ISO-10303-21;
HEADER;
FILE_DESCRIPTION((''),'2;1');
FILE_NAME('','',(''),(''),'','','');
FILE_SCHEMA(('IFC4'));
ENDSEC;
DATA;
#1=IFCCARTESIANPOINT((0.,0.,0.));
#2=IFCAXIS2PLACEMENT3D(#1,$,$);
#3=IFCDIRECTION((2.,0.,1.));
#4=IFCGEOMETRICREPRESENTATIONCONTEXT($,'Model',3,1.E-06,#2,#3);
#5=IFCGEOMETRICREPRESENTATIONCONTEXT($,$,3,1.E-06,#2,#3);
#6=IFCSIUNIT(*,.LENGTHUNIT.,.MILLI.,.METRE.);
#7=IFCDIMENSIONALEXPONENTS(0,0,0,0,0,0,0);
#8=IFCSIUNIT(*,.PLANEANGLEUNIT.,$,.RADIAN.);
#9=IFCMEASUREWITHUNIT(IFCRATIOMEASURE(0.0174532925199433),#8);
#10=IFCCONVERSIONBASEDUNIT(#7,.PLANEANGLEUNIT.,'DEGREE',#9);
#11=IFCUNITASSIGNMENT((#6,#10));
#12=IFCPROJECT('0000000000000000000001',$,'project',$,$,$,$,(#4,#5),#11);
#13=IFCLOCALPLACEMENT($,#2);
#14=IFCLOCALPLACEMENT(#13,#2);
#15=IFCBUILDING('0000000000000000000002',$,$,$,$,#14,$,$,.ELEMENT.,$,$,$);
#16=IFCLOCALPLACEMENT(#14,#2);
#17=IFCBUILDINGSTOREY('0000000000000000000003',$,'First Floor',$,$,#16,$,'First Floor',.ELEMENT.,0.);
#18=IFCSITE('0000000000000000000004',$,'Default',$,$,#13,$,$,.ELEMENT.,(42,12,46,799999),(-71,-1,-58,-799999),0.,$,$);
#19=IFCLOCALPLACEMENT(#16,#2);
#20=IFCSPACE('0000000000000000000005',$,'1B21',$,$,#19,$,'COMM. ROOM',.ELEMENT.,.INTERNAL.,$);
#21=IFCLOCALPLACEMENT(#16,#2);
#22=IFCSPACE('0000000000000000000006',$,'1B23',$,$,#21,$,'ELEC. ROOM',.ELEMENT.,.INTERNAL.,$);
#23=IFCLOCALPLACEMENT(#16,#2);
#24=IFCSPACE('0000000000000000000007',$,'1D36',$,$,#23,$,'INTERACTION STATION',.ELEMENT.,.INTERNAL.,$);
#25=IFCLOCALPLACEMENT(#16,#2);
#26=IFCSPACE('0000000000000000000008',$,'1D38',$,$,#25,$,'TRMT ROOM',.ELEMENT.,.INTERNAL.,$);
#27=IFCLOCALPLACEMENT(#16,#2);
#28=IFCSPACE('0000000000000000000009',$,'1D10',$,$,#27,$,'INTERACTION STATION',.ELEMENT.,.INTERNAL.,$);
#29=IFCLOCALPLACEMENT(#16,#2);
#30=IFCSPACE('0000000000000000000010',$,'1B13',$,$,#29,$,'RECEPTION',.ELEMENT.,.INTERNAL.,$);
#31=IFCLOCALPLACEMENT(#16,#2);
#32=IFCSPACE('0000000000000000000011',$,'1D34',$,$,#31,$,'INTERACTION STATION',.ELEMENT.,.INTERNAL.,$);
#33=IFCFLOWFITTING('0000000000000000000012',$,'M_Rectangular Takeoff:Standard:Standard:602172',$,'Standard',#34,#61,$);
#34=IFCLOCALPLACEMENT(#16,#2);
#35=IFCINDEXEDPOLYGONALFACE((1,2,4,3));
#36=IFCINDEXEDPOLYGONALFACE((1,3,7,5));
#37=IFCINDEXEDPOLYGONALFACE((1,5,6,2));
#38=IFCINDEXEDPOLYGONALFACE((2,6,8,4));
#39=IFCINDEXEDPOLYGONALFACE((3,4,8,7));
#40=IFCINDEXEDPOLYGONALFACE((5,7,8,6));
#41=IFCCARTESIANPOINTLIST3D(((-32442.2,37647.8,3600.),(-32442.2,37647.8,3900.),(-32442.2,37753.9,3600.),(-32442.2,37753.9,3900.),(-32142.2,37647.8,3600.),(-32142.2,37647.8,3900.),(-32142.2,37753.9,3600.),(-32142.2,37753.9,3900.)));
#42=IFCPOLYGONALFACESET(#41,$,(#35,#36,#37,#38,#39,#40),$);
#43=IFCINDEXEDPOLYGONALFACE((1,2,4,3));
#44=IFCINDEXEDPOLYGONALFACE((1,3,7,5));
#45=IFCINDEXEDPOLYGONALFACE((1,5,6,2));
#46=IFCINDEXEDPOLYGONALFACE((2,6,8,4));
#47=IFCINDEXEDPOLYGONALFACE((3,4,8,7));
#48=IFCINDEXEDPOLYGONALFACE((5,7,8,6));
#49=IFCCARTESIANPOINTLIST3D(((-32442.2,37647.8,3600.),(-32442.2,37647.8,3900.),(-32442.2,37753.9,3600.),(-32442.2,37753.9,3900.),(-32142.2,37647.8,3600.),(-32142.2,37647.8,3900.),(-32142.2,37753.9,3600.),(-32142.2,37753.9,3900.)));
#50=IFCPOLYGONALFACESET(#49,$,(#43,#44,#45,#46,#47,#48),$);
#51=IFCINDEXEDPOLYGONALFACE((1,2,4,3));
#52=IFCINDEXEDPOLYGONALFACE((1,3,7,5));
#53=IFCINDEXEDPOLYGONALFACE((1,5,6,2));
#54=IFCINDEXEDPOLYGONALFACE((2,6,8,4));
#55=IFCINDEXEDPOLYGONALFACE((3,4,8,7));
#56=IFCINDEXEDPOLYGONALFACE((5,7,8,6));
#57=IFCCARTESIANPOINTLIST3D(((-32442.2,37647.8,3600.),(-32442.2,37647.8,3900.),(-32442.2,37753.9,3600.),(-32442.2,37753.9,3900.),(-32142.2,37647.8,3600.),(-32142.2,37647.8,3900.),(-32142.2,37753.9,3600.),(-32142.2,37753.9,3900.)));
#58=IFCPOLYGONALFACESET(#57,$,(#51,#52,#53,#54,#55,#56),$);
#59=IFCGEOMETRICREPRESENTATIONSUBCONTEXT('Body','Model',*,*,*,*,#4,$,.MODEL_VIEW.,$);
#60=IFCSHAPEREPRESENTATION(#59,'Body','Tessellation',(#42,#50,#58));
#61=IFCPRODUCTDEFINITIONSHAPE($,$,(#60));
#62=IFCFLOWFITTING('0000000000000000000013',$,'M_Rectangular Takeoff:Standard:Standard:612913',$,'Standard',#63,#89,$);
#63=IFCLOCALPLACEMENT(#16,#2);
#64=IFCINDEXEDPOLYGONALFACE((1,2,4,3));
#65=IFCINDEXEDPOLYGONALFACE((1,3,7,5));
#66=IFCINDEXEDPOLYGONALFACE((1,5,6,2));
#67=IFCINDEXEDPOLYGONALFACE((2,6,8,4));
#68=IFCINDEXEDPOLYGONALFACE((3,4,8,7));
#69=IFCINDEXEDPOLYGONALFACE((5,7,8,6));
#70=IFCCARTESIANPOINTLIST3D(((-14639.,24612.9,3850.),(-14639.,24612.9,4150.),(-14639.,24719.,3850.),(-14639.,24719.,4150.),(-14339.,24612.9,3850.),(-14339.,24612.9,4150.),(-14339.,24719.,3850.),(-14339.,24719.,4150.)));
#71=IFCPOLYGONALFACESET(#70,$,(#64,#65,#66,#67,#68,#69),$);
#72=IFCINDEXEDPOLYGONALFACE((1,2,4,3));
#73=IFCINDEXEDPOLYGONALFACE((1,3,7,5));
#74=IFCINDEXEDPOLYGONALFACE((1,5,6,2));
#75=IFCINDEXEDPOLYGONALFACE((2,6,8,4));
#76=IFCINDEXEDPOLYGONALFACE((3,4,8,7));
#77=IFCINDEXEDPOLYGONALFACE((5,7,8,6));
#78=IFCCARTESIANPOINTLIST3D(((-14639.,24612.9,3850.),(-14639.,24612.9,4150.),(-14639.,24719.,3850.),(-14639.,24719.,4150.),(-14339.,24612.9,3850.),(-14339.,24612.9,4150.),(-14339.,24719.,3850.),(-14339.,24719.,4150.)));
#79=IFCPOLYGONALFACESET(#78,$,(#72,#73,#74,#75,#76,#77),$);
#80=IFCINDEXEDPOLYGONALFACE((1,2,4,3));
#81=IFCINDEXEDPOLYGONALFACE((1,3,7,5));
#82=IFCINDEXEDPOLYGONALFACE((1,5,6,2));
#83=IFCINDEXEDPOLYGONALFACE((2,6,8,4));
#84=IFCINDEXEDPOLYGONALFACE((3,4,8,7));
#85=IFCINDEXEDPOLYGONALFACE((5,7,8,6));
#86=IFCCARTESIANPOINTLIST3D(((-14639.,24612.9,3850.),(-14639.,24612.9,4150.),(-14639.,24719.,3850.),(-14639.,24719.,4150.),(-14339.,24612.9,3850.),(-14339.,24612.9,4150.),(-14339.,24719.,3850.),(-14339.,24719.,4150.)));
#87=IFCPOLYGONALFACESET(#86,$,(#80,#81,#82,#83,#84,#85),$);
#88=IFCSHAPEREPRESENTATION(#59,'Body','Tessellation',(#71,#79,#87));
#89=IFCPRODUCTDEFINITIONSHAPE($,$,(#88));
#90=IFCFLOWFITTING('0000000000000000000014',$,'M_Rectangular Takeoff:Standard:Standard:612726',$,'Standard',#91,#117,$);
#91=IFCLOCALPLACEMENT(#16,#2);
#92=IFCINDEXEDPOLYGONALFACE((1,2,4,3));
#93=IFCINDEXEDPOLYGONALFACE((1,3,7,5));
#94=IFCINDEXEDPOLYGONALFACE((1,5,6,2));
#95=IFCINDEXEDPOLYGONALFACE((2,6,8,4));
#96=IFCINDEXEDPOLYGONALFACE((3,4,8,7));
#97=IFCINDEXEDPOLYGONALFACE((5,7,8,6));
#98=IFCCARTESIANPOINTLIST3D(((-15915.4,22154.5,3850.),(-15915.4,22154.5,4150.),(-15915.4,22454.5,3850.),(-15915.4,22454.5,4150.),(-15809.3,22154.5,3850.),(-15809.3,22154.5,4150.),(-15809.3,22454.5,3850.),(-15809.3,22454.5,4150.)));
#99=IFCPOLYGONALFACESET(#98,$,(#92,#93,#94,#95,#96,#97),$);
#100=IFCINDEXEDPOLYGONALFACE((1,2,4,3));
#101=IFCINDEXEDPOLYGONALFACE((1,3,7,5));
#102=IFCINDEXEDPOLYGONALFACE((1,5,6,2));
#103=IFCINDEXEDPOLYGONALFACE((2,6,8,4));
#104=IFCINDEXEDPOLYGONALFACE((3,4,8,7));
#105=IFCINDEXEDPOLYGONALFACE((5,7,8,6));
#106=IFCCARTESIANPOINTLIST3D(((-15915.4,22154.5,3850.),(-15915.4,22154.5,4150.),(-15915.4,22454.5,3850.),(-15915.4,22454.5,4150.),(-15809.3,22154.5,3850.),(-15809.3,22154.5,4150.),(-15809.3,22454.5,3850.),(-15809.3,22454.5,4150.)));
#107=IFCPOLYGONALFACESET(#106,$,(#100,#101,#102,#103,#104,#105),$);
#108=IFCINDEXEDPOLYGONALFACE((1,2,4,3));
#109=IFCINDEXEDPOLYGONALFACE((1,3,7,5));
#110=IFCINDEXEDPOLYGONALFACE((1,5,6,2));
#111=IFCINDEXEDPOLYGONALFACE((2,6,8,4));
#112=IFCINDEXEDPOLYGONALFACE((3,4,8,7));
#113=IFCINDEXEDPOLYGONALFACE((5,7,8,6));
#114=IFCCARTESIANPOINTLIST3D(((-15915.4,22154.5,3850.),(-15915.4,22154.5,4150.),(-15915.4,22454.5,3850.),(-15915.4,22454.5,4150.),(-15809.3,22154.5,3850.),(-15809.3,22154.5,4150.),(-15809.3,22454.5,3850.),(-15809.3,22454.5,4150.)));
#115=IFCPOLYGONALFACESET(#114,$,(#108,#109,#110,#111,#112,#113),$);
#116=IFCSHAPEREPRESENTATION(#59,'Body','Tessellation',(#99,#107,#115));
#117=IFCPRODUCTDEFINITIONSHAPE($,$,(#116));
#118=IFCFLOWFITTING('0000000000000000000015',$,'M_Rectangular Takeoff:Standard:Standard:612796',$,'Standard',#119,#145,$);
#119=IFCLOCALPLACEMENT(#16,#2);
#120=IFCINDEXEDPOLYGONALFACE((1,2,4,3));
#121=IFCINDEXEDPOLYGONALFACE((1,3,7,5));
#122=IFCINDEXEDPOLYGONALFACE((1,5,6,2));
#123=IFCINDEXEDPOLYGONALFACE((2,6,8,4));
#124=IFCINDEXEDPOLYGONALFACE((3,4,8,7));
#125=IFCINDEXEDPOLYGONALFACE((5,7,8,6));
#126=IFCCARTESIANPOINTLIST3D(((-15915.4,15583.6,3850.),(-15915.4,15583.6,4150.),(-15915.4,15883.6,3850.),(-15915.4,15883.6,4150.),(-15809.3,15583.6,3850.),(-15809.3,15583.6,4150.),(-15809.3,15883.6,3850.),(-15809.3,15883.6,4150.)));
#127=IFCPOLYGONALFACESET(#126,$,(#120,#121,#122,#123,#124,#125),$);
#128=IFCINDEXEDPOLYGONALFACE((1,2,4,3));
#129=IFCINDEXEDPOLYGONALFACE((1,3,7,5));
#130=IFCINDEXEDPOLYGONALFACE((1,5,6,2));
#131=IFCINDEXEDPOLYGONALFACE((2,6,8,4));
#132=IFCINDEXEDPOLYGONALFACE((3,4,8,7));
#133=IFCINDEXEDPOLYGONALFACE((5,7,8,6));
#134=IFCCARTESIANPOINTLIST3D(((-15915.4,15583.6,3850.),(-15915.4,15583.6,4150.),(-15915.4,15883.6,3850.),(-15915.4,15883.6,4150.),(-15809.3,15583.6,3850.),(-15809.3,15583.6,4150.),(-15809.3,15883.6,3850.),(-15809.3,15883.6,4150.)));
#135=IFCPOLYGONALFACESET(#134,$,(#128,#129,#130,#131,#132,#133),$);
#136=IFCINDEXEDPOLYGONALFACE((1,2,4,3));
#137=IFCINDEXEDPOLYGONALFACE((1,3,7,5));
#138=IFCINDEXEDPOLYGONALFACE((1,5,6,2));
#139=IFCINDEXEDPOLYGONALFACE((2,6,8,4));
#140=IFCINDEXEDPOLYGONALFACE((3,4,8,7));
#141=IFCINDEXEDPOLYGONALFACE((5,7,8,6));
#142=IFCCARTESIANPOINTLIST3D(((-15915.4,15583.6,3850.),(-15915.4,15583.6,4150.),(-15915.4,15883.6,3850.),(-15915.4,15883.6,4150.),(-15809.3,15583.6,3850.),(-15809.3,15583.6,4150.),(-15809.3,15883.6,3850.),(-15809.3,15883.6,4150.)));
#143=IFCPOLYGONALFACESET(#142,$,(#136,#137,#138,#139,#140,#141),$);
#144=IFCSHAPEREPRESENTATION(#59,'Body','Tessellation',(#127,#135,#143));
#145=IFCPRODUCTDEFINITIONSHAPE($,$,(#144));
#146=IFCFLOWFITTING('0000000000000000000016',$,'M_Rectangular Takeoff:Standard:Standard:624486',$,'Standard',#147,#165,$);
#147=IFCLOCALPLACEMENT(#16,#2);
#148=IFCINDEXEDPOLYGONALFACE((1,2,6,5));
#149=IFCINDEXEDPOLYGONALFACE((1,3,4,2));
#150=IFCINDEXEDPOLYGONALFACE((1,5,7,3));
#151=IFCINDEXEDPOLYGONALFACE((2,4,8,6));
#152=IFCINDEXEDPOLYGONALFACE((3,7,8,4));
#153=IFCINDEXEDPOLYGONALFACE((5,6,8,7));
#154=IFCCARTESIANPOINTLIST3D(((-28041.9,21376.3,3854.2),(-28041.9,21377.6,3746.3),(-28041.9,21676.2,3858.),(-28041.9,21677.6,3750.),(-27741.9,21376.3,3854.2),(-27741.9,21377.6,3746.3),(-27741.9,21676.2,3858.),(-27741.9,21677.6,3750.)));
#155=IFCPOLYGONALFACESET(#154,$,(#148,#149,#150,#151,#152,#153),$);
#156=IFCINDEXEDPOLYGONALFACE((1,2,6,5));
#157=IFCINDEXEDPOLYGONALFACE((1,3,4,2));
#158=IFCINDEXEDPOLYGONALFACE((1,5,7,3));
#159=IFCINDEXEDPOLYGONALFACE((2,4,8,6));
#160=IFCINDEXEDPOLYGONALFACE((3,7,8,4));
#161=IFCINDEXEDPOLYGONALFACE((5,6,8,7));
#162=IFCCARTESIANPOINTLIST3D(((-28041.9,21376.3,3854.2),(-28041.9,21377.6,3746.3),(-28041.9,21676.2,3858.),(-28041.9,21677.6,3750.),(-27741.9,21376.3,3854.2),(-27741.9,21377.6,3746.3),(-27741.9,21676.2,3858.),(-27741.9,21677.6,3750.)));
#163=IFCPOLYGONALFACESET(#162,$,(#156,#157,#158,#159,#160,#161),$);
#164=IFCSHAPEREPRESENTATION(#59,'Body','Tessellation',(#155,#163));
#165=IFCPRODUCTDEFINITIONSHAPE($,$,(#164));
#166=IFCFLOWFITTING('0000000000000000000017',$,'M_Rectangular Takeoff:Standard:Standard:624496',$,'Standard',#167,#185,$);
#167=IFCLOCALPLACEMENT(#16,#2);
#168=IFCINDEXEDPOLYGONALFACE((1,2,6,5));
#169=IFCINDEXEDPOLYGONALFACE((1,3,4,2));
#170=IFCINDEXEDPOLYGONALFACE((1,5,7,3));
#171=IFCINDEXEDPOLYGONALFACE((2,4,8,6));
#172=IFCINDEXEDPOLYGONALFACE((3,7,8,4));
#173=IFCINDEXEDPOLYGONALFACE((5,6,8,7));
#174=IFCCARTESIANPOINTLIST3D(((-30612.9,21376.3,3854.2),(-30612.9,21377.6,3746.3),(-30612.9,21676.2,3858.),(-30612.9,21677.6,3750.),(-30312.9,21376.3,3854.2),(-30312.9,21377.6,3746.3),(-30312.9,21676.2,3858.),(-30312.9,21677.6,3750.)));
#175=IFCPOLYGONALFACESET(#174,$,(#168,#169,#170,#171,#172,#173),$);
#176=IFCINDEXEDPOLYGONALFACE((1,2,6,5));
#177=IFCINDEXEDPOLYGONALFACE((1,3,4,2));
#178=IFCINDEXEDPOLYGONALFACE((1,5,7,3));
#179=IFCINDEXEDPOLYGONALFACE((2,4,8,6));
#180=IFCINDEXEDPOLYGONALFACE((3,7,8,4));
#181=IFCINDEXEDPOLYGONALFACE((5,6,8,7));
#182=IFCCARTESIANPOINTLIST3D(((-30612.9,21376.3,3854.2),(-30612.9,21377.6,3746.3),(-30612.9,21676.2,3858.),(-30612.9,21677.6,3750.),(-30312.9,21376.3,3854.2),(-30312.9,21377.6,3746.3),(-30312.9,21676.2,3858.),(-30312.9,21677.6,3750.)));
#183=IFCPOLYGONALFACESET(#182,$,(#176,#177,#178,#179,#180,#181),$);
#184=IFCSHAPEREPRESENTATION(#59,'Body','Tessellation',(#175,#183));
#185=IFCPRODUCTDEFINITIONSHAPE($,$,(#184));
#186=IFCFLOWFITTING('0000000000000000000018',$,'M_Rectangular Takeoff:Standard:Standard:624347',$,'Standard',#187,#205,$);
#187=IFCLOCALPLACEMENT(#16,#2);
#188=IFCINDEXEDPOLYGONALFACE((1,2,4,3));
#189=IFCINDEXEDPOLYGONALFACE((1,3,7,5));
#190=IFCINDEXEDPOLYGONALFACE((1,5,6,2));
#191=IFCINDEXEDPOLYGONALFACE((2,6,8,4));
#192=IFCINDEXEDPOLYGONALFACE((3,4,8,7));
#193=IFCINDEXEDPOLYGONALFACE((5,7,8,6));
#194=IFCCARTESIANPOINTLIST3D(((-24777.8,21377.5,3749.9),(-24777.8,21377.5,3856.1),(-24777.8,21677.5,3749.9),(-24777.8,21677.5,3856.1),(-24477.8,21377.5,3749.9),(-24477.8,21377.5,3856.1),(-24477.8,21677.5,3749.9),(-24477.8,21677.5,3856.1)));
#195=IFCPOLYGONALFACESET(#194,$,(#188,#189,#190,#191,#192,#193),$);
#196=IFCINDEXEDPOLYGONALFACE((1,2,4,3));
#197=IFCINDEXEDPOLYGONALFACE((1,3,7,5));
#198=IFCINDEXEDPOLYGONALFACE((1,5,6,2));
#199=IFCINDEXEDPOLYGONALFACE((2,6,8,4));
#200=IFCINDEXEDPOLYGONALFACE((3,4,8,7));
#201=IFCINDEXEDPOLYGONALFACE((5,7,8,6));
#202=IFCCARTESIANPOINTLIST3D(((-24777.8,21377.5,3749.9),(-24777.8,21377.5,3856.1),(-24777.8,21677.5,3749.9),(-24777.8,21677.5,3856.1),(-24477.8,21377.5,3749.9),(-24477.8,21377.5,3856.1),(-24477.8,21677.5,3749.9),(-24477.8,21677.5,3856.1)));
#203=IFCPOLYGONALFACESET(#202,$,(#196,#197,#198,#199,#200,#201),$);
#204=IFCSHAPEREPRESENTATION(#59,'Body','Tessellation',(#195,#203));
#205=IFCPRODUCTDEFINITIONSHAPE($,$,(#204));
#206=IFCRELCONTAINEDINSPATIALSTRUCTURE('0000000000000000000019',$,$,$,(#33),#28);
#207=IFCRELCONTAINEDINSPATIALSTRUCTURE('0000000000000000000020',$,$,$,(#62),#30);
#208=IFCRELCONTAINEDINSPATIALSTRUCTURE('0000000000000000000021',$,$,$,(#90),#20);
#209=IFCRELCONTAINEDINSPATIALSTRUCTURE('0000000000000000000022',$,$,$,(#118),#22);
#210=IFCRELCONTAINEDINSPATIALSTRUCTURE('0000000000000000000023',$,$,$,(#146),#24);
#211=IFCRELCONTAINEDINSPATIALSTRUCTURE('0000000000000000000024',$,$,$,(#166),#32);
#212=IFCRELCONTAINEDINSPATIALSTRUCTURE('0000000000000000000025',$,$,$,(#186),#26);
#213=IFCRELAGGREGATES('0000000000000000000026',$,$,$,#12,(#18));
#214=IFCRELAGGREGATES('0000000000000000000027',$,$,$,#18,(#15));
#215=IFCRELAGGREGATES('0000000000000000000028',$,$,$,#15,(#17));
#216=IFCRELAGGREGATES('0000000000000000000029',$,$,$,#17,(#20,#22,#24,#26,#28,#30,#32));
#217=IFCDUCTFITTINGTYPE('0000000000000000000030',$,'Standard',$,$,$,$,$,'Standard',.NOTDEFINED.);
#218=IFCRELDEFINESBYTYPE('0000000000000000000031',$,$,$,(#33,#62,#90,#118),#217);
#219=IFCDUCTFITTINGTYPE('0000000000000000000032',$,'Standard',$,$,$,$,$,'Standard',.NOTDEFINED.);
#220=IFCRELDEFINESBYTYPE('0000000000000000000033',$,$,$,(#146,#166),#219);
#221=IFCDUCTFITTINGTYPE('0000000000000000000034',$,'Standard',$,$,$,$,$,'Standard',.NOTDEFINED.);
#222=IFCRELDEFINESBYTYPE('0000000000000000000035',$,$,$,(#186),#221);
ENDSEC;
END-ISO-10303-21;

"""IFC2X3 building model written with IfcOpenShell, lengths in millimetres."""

from ifc_helpers import new_model, entity, si_unit, converted_unit, direction, frame, frame_2d, origin, place, context, subcontext, project, spatial, rectangle, extrude, source, transform, mapped, type_object, type_shapes, element, save


model = new_model("IFC2X3")

# Units and contexts
model_context = context("Model", 3, precision=1e-06, world=origin(), true_north=direction((2.0, 0.0, 1.0)))
context_of_model = context(None, 3, precision=1e-06, world=origin(), true_north=direction((2.0, 0.0, 1.0)))
body_context = subcontext(model_context, "Body", "Model", "MODEL_VIEW")
ifc_project = project(units=[si_unit("LENGTHUNIT", "METRE", prefix="MILLI"), converted_unit("PLANEANGLEUNIT", "DEGREE", entity("IfcRatioMeasure", 0.0174532925199433), si_unit("PLANEANGLEUNIT", "RADIAN"), dimensions=[0, 0, 0, 0, 0, 0, 0])], contexts=[model_context, context_of_model])

# Site, building, storey, space
site_placement = place(None, origin())
site = spatial("IfcSite", under=ifc_project, at=site_placement, Name="Default", CompositionType="ELEMENT", RefLatitude=(42, 12, 46, 799999), RefLongitude=(-71, -1, -58, -799999), RefElevation=0.0)
building_placement = place(site_placement, origin())
building = spatial("IfcBuilding", under=site, at=building_placement, CompositionType="ELEMENT")
storey_placement = place(building_placement, origin())
storey = spatial("IfcBuildingStorey", under=building, at=storey_placement, Name="First Floor", LongName="First Floor", CompositionType="ELEMENT", Elevation=0.0)
space_1_placement = place(storey_placement, origin())
space_1 = spatial("IfcSpace", under=storey, at=space_1_placement, Name="1B21", LongName="COMM. ROOM", CompositionType="ELEMENT", InteriorOrExteriorSpace="INTERNAL")

# Shared definitions
space_2_placement = place(storey_placement, origin())
space_2 = spatial("IfcSpace", under=storey, at=space_2_placement, Name="1B23", LongName="ELEC. ROOM", CompositionType="ELEMENT", InteriorOrExteriorSpace="INTERNAL")

# Shared definitions
space_3_placement = place(storey_placement, origin())
space_3 = spatial("IfcSpace", under=storey, at=space_3_placement, Name="1D36", LongName="INTERACTION STATION", CompositionType="ELEMENT", InteriorOrExteriorSpace="INTERNAL")

# Shared definitions
space_4_placement = place(storey_placement, origin())
space_4 = spatial("IfcSpace", under=storey, at=space_4_placement, Name="1D38", LongName="TRMT ROOM", CompositionType="ELEMENT", InteriorOrExteriorSpace="INTERNAL")

# Shared definitions
space_5_placement = place(storey_placement, origin())
space_5 = spatial("IfcSpace", under=storey, at=space_5_placement, Name="1D10", LongName="INTERACTION STATION", CompositionType="ELEMENT", InteriorOrExteriorSpace="INTERNAL")

# Flow fitting
duct_fitting_type_1 = type_object("IfcDuctFittingType", Name="Standard", ElementType="Standard", PredefinedType="NOTDEFINED")
shared_shape_1 = source(origin(), body_context, "Body", "SweptSolid", [
    extrude(rectangle(XDim=106.1, YDim=300.0, at=frame_2d((0.0, 0.0), x_axis=(1.0, 0.0))), frame((47.0, 0.0, -150.0)), (0.0, 0.0, 1.0), 300.0),
    extrude(rectangle(XDim=106.1, YDim=300.0, at=frame_2d((0.0, 0.0), x_axis=(1.0, 0.0))), frame((47.0, 0.0, -150.0)), (0.0, 0.0, 1.0), 300.0),
    extrude(rectangle(XDim=106.1, YDim=300.0, at=frame_2d((0.0, 0.0), x_axis=(1.0, 0.0))), frame((47.0, 0.0, -150.0)), (0.0, 0.0, 1.0), 300.0),
])
type_shapes(duct_fitting_type_1, [shared_shape_1])
flow_fitting_1_placement = place(space_5_placement, frame((-32292.2, 37653.9, 3750.0), z_axis=(0.0, 0.0, -1.0), x_axis=(0.0, 1.0, 0.0)))
element("IfcFlowFitting", 1, at=flow_fitting_1_placement, inside=space_5, type_object=duct_fitting_type_1, Name="M_Rectangular Takeoff:Standard:Standard:602172", ObjectType="Standard", context=body_context, shape_type="MappedRepresentation", body=[
    mapped(shared_shape_1, transform((0.0, 0.0, 0.0), scale=1.0)),
])

# Shared definitions
space_6_placement = place(storey_placement, origin())
space_6 = spatial("IfcSpace", under=storey, at=space_6_placement, Name="1B13", LongName="RECEPTION", CompositionType="ELEMENT", InteriorOrExteriorSpace="INTERNAL")

# Flow fittings
flow_fitting_2_placement = place(space_6_placement, frame((-14489.0, 24619.0, 4000.0), z_axis=(0.0, 0.0, -1.0), x_axis=(0.0, 1.0, 0.0)))
element("IfcFlowFitting", 2, at=flow_fitting_2_placement, inside=space_6, type_object=duct_fitting_type_1, Name="M_Rectangular Takeoff:Standard:Standard:612913", ObjectType="Standard", context=body_context, shape_type="MappedRepresentation", body=[
    mapped(shared_shape_1, transform((0.0, 0.0, 0.0), scale=1.0)),
])
flow_fitting_3_placement = place(space_1_placement, frame((-15815.4, 22304.5, 4000.0), z_axis=(0.0, 0.0, -1.0), x_axis=(-1.0, 0.0, 0.0)))
element("IfcFlowFitting", 3, at=flow_fitting_3_placement, inside=space_1, type_object=duct_fitting_type_1, Name="M_Rectangular Takeoff:Standard:Standard:612726", ObjectType="Standard", context=body_context, shape_type="MappedRepresentation", body=[
    mapped(shared_shape_1, transform((0.0, 0.0, 0.0), scale=1.0)),
])
flow_fitting_4_placement = place(space_2_placement, frame((-15815.4, 15733.6, 4000.0), z_axis=(0.0, 0.0, -1.0), x_axis=(-1.0, 0.0, 0.0)))
element("IfcFlowFitting", 4, at=flow_fitting_4_placement, inside=space_2, type_object=duct_fitting_type_1, Name="M_Rectangular Takeoff:Standard:Standard:612796", ObjectType="Standard", context=body_context, shape_type="MappedRepresentation", body=[
    mapped(shared_shape_1, transform((0.0, 0.0, 0.0), scale=1.0)),
])

# Flow fitting
duct_fitting_type_2 = type_object("IfcDuctFittingType", Name="Standard", ElementType="Standard", PredefinedType="NOTDEFINED")
shared_shape_2 = source(origin(), body_context, "Body", "SweptSolid", [
    extrude(rectangle(XDim=300.0, YDim=108.0, at=frame_2d((0.0, 0.0), x_axis=(1.0, 0.0))), frame((47.9, 0.0, -150.0), z_axis=(0.0, 0.0, 1.0), x_axis=(0.0, -1.0, 0.0)), (0.0, 0.0, 1.0), 300.0),
    extrude(rectangle(XDim=300.0, YDim=108.0, at=frame_2d((0.0, 0.0), x_axis=(1.0, 0.0))), frame((47.9, 0.0, -150.0), z_axis=(0.0, 0.0, 1.0), x_axis=(0.0, -1.0, 0.0)), (0.0, 0.0, 1.0), 300.0),
])
type_shapes(duct_fitting_type_2, [shared_shape_2])
flow_fitting_5_placement = place(space_3_placement, frame((-27891.9, 21526.3, 3850.0), z_axis=(1.0, 0.0, 0.0), x_axis=(0.0, 0.012398, -0.999923)))
element("IfcFlowFitting", 5, at=flow_fitting_5_placement, inside=space_3, type_object=duct_fitting_type_2, Name="M_Rectangular Takeoff:Standard:Standard:624486", ObjectType="Standard", context=body_context, shape_type="MappedRepresentation", body=[
    mapped(shared_shape_2, transform((0.0, 0.0, 0.0), scale=1.0)),
])

# Shared definitions
space_7_placement = place(storey_placement, origin())
space_7 = spatial("IfcSpace", under=storey, at=space_7_placement, Name="1D34", LongName="INTERACTION STATION", CompositionType="ELEMENT", InteriorOrExteriorSpace="INTERNAL")

# Flow fittings
flow_fitting_6_placement = place(space_7_placement, frame((-30462.9, 21526.3, 3850.0), z_axis=(1.0, 0.0, 0.0), x_axis=(0.0, 0.012398, -0.999923)))
element("IfcFlowFitting", 6, at=flow_fitting_6_placement, inside=space_7, type_object=duct_fitting_type_2, Name="M_Rectangular Takeoff:Standard:Standard:624496", ObjectType="Standard", context=body_context, shape_type="MappedRepresentation", body=[
    mapped(shared_shape_2, transform((0.0, 0.0, 0.0), scale=1.0)),
])
duct_fitting_type_3 = type_object("IfcDuctFittingType", Name="Standard", ElementType="Standard", PredefinedType="NOTDEFINED")
shared_shape_3 = source(origin(), body_context, "Body", "SweptSolid", [
    extrude(rectangle(XDim=300.0, YDim=106.2, at=frame_2d((0.0, 0.0), x_axis=(1.0, 0.0))), frame((47.0, 0.0, -150.0), z_axis=(0.0, 0.0, 1.0), x_axis=(0.0, -1.0, 0.0)), (0.0, 0.0, 1.0), 300.0),
    extrude(rectangle(XDim=300.0, YDim=106.2, at=frame_2d((0.0, 0.0), x_axis=(1.0, 0.0))), frame((47.0, 0.0, -150.0), z_axis=(0.0, 0.0, 1.0), x_axis=(0.0, -1.0, 0.0)), (0.0, 0.0, 1.0), 300.0),
])
type_shapes(duct_fitting_type_3, [shared_shape_3])
flow_fitting_7_placement = place(space_4_placement, frame((-24627.8, 21527.5, 3850.0), z_axis=(1.0, 0.0, 0.0), x_axis=(0.0, 0.0, -1.0)))
element("IfcFlowFitting", 7, at=flow_fitting_7_placement, inside=space_4, type_object=duct_fitting_type_3, Name="M_Rectangular Takeoff:Standard:Standard:624347", ObjectType="Standard", context=body_context, shape_type="MappedRepresentation", body=[
    mapped(shared_shape_3, transform((0.0, 0.0, 0.0), scale=1.0)),
])

save(model, "model.ifc")
